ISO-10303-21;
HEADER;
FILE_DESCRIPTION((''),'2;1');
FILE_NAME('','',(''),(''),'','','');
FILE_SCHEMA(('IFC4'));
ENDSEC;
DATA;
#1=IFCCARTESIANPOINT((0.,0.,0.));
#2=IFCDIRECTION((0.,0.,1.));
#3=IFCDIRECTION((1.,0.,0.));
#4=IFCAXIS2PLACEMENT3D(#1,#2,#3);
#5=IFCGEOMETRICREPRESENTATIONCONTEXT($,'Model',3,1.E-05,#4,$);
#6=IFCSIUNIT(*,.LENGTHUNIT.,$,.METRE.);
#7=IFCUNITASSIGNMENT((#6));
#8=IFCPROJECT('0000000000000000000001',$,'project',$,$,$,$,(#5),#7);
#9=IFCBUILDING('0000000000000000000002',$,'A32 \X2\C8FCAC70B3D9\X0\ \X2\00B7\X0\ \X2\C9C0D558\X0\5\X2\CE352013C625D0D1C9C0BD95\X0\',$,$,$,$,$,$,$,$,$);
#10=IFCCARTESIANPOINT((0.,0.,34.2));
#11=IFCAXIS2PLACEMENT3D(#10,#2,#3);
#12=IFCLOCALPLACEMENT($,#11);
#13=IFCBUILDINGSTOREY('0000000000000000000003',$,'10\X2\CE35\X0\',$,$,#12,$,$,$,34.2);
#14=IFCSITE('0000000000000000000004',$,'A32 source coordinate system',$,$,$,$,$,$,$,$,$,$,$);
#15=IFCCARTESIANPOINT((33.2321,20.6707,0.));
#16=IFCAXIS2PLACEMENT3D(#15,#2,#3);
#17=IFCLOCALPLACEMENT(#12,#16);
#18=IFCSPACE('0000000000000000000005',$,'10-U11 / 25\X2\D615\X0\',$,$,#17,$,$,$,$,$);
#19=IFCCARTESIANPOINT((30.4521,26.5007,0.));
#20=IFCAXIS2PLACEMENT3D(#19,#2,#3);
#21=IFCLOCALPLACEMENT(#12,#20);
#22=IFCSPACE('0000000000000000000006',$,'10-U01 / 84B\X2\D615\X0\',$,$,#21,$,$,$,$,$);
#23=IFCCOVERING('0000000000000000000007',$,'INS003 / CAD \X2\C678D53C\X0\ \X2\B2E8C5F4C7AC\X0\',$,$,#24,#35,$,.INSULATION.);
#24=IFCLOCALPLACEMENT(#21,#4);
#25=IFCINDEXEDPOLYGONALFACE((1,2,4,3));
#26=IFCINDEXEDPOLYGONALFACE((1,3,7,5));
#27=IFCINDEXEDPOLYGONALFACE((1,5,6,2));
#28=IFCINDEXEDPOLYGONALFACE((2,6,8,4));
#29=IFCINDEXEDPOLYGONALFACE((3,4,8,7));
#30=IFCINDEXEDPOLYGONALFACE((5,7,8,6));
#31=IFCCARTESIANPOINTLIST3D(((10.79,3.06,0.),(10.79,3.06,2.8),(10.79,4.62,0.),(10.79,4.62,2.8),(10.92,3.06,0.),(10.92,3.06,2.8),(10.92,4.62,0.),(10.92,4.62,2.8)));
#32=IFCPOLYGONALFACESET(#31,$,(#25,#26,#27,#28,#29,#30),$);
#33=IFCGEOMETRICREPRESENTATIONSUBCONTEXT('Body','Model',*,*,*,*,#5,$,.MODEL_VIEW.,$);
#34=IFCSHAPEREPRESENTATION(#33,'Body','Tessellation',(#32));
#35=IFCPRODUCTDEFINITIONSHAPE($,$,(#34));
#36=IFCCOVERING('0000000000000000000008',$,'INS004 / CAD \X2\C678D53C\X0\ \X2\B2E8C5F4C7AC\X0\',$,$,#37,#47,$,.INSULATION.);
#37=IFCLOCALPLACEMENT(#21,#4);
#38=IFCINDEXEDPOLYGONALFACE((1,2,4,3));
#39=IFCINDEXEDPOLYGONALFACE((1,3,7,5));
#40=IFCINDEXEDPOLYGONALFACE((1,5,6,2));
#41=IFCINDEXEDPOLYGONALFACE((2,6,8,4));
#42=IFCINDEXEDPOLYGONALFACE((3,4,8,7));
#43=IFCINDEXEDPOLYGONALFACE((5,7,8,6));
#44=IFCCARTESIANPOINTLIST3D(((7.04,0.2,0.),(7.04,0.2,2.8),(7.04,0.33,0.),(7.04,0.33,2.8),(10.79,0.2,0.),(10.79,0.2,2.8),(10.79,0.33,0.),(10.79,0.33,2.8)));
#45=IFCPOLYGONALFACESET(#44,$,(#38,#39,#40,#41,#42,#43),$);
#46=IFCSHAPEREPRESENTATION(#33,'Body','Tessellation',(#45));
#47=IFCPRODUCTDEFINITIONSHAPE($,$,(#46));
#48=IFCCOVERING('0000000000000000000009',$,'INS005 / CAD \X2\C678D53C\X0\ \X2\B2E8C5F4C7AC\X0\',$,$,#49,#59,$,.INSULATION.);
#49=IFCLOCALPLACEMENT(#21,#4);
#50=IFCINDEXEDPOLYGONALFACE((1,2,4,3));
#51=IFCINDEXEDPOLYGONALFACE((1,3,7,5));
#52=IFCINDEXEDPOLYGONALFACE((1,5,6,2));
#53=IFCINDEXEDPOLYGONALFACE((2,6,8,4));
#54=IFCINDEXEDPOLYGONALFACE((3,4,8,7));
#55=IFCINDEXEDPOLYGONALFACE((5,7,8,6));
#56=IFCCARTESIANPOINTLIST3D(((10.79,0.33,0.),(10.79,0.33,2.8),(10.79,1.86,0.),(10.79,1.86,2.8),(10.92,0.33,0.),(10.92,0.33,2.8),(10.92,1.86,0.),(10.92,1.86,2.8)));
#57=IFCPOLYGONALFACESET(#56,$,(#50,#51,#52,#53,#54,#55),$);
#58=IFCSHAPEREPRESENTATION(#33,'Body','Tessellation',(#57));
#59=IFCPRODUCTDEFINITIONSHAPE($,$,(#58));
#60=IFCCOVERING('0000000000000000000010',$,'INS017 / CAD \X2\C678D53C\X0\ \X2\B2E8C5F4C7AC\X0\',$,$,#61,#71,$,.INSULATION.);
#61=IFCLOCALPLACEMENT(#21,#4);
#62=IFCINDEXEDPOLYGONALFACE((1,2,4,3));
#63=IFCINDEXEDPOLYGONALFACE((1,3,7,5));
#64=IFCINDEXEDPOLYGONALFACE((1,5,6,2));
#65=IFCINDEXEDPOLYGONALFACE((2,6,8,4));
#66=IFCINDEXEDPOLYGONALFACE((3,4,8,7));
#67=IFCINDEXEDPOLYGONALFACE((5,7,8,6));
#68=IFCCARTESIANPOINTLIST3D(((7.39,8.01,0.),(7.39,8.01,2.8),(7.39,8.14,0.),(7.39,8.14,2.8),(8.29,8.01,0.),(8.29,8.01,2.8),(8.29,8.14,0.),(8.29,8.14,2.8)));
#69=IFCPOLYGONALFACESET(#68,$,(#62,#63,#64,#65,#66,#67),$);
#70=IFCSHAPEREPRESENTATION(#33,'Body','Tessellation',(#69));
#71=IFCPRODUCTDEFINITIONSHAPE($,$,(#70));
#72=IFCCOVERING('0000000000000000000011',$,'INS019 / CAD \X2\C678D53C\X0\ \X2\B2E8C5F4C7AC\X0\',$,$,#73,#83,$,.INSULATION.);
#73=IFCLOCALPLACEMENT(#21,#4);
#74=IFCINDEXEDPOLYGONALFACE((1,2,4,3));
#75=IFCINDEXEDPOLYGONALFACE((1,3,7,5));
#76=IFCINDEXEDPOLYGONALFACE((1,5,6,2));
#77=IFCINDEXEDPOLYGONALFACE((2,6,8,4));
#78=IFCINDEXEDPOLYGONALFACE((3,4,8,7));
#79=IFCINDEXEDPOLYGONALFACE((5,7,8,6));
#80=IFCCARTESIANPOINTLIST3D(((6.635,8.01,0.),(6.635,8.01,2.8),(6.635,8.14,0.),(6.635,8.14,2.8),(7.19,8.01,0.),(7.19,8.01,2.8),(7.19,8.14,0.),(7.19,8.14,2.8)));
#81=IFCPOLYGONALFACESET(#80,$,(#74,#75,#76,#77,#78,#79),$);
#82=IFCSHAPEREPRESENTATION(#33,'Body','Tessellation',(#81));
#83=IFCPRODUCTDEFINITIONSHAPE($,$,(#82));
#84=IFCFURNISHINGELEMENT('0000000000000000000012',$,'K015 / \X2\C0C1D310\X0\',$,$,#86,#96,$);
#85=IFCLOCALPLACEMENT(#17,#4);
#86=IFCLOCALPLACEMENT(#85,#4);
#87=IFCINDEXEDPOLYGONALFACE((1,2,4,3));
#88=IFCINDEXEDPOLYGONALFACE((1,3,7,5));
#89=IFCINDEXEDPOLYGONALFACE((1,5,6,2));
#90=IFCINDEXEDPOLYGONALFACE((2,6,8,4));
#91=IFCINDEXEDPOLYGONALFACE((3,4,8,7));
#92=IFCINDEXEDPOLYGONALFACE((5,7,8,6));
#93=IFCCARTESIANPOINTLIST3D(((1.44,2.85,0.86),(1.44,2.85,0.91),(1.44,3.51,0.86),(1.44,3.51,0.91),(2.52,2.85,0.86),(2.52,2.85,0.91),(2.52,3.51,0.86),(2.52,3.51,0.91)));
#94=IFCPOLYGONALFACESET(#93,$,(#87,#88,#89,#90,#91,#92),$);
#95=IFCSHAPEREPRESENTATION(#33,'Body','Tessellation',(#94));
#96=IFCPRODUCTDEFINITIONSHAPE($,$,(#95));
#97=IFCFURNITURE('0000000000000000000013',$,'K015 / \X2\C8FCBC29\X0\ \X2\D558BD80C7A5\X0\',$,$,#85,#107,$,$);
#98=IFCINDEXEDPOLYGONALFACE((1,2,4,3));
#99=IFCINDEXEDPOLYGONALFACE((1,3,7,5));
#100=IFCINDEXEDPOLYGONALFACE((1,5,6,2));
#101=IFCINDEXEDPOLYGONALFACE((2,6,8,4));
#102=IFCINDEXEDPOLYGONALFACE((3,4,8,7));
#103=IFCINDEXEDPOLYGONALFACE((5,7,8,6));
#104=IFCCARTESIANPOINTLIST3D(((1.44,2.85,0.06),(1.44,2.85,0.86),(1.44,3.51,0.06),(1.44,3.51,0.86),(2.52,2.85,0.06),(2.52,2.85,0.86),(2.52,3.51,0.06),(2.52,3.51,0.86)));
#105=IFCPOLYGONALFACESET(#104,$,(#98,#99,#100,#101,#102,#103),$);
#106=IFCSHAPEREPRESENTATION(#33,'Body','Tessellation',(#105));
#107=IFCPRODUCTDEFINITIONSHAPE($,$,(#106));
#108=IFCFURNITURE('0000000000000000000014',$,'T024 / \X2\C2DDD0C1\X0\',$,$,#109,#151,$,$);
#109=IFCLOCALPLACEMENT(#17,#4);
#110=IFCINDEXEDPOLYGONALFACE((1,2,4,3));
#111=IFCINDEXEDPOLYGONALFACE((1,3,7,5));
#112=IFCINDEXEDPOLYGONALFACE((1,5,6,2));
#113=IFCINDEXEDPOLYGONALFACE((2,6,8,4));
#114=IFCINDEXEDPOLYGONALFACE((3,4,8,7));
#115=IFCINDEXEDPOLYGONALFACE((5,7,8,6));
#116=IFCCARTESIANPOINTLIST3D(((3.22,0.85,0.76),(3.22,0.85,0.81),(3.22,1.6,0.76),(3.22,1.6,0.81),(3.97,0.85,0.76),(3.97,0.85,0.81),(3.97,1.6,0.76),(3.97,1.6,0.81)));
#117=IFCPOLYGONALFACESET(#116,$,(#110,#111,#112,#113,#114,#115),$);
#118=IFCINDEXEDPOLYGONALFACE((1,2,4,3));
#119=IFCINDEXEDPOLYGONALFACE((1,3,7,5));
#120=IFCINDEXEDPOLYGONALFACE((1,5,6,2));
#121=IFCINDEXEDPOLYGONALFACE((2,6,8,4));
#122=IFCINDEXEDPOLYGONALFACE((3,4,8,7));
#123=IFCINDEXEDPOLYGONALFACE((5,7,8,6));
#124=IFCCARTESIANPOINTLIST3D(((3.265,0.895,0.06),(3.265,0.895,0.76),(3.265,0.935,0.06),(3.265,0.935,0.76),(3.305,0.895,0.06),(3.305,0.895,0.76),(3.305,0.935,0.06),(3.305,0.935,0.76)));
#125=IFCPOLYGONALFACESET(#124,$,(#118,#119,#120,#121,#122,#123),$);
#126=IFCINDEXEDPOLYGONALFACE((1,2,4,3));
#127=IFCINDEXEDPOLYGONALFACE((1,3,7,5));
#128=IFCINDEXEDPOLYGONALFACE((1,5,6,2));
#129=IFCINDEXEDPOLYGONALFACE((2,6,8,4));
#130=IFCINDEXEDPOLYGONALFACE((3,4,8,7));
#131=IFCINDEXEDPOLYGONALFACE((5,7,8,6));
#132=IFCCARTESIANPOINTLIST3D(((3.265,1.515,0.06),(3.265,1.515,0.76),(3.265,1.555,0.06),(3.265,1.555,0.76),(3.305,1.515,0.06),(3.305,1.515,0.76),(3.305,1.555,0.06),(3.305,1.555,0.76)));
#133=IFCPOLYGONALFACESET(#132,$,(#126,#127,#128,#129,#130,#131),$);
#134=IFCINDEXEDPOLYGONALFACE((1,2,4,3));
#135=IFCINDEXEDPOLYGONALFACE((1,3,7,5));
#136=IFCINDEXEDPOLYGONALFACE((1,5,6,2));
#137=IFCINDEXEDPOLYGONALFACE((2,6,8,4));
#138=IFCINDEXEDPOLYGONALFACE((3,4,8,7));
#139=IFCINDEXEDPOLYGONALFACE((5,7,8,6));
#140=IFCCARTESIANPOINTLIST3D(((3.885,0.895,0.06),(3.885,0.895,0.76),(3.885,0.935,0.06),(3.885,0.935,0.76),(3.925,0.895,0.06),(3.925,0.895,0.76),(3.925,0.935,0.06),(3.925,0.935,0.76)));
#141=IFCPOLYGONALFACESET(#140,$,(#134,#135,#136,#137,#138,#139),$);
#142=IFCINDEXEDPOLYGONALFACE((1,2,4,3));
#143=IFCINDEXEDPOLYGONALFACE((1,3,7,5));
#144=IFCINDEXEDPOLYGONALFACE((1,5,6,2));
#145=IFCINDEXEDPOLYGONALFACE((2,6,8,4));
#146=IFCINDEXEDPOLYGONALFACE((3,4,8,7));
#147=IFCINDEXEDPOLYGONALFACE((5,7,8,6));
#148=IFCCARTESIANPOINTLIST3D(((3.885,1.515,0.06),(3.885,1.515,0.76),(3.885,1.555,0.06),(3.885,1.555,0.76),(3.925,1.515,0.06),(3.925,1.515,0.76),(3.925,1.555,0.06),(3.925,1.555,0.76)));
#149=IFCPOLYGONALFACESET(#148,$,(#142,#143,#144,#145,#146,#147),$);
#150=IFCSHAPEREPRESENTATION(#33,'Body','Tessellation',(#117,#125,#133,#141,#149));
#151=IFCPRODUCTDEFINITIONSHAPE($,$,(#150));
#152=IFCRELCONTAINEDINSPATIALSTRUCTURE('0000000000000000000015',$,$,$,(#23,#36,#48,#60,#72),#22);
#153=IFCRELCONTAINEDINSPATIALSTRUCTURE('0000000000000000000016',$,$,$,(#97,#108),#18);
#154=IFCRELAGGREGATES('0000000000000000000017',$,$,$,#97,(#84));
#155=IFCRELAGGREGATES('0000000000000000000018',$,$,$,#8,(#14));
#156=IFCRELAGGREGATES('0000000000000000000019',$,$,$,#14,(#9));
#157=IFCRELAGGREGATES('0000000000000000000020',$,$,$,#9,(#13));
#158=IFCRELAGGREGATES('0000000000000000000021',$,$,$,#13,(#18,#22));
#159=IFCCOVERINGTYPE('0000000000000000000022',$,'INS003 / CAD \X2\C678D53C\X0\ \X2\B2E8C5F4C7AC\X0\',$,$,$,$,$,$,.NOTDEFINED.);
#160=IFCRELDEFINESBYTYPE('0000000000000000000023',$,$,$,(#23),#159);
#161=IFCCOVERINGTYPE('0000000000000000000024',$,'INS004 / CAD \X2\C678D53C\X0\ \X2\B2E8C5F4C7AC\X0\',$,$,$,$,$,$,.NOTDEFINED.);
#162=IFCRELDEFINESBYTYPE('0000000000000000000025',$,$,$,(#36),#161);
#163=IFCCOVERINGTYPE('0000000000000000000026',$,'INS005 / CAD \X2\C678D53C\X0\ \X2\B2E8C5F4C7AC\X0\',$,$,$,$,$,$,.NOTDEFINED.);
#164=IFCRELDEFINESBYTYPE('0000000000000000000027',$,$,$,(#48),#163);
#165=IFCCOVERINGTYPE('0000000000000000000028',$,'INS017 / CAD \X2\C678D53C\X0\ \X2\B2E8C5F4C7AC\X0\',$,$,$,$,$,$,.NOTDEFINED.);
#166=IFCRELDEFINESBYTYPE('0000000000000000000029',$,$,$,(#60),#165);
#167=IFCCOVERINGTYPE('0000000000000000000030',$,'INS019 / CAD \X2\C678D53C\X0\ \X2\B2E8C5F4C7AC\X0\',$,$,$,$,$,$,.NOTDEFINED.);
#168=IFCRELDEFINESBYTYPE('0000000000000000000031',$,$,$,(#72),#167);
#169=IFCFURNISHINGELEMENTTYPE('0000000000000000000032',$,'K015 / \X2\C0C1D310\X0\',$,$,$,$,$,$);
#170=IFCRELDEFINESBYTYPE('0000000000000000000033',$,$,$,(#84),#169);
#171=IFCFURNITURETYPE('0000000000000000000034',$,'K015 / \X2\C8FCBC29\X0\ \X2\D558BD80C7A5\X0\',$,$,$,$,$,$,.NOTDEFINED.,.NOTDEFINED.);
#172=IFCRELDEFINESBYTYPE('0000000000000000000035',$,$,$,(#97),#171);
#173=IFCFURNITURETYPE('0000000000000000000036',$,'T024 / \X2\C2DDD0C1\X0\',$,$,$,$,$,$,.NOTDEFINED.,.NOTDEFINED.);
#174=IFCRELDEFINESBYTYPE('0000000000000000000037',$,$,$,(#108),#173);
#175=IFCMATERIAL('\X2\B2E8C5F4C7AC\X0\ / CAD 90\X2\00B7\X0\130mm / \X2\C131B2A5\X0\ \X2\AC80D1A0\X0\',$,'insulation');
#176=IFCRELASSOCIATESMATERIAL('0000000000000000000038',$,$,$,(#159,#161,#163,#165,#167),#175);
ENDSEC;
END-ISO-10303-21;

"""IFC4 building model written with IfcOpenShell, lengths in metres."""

from ifc_helpers import new_model, si_unit, frame, origin, origin_with_axes, place, context, subcontext, project, spatial, polyline, outline, extrude, source, transform, mapped, material, type_object, type_shapes, element, aggregate, save


model = new_model("IFC4")

# Units and contexts
model_context = context("Model", 3, precision=1e-05, world=origin_with_axes())
body_context = subcontext(model_context, "Body", "Model", "MODEL_VIEW")
ifc_project = project(units=[si_unit("LENGTHUNIT", "METRE")], contexts=[model_context])

# Site, building, storey, space
site = spatial("IfcSite", under=ifc_project, Name="A32 source coordinate system")
building = spatial("IfcBuilding", under=site, Name="A32 주거동 · 지하5층–옥탑지붕")
storey_placement = place(None, frame((0.0, 0.0, 34.2), z_axis=(0.0, 0.0, 1.0), x_axis=(1.0, 0.0, 0.0)))
storey = spatial("IfcBuildingStorey", under=building, at=storey_placement, Name="10층", Elevation=34.2)
space_1_placement = place(storey_placement, frame((33.2321, 20.6707, 0.0), z_axis=(0.0, 0.0, 1.0), x_axis=(1.0, 0.0, 0.0)))
space_1 = spatial("IfcSpace", under=storey, at=space_1_placement, Name="10-U11 / 25형")

# Shared definitions
space_2_placement = place(storey_placement, frame((30.4521, 26.5007, 0.0), z_axis=(0.0, 0.0, 1.0), x_axis=(1.0, 0.0, 0.0)))
space_2 = spatial("IfcSpace", under=storey, at=space_2_placement, Name="10-U01 / 84B형")

# Coverings
ifc_material = material(Name="단열재 / CAD 90·130mm / 성능 검토", Category="insulation")
covering_type_1 = type_object("IfcCoveringType", Name="INS003 / CAD 외피 단열재", PredefinedType="NOTDEFINED", material=ifc_material)
shared_shape_1 = source(origin(), body_context, "Body", "SweptSolid", [
    extrude(outline(polyline([(10.79, 3.06), (10.79, 4.62), (10.92, 4.62), (10.92, 3.06), (10.79, 3.06)])), origin(), (0.0, 0.0, 1.0), 2.8),
])
type_shapes(covering_type_1, [shared_shape_1])
covering_1_placement = place(space_2_placement, origin_with_axes())
element("IfcCovering", 1, at=covering_1_placement, inside=space_2, type_object=covering_type_1, Name="INS003 / CAD 외피 단열재", PredefinedType="INSULATION", context=body_context, shape_type="MappedRepresentation", body=[
    mapped(shared_shape_1, transform((0.0, 0.0, 0.0), scale=1.0)),
])
covering_type_2 = type_object("IfcCoveringType", Name="INS004 / CAD 외피 단열재", PredefinedType="NOTDEFINED", material=ifc_material)
shared_shape_2 = source(origin(), body_context, "Body", "SweptSolid", [
    extrude(outline(polyline([(7.04, 0.33), (10.79, 0.33), (10.79, 0.2), (7.04, 0.2), (7.04, 0.33)])), origin(), (0.0, 0.0, 1.0), 2.8),
])
type_shapes(covering_type_2, [shared_shape_2])
covering_2_placement = place(space_2_placement, origin_with_axes())
element("IfcCovering", 2, at=covering_2_placement, inside=space_2, type_object=covering_type_2, Name="INS004 / CAD 외피 단열재", PredefinedType="INSULATION", context=body_context, shape_type="MappedRepresentation", body=[
    mapped(shared_shape_2, transform((0.0, 0.0, 0.0), scale=1.0)),
])
covering_type_3 = type_object("IfcCoveringType", Name="INS005 / CAD 외피 단열재", PredefinedType="NOTDEFINED", material=ifc_material)
shared_shape_3 = source(origin(), body_context, "Body", "SweptSolid", [
    extrude(outline(polyline([(10.79, 0.33), (10.79, 1.86), (10.92, 1.86), (10.92, 0.33), (10.79, 0.33)])), origin(), (0.0, 0.0, 1.0), 2.8),
])
type_shapes(covering_type_3, [shared_shape_3])
covering_3_placement = place(space_2_placement, origin_with_axes())
element("IfcCovering", 3, at=covering_3_placement, inside=space_2, type_object=covering_type_3, Name="INS005 / CAD 외피 단열재", PredefinedType="INSULATION", context=body_context, shape_type="MappedRepresentation", body=[
    mapped(shared_shape_3, transform((0.0, 0.0, 0.0), scale=1.0)),
])
covering_type_4 = type_object("IfcCoveringType", Name="INS017 / CAD 외피 단열재", PredefinedType="NOTDEFINED", material=ifc_material)
shared_shape_4 = source(origin(), body_context, "Body", "SweptSolid", [
    extrude(outline(polyline([(8.29, 8.01), (7.39, 8.01), (7.39, 8.14), (8.29, 8.14), (8.29, 8.01)])), origin(), (0.0, 0.0, 1.0), 2.8),
])
type_shapes(covering_type_4, [shared_shape_4])
covering_4_placement = place(space_2_placement, origin_with_axes())
element("IfcCovering", 4, at=covering_4_placement, inside=space_2, type_object=covering_type_4, Name="INS017 / CAD 외피 단열재", PredefinedType="INSULATION", context=body_context, shape_type="MappedRepresentation", body=[
    mapped(shared_shape_4, transform((0.0, 0.0, 0.0), scale=1.0)),
])
covering_type_5 = type_object("IfcCoveringType", Name="INS019 / CAD 외피 단열재", PredefinedType="NOTDEFINED", material=ifc_material)
shared_shape_5 = source(origin(), body_context, "Body", "SweptSolid", [
    extrude(outline(polyline([(6.635, 8.01), (6.635, 8.14), (7.19, 8.14), (7.19, 8.01), (6.635, 8.01)])), origin(), (0.0, 0.0, 1.0), 2.8),
])
type_shapes(covering_type_5, [shared_shape_5])
covering_5_placement = place(space_2_placement, origin_with_axes())
element("IfcCovering", 5, at=covering_5_placement, inside=space_2, type_object=covering_type_5, Name="INS019 / CAD 외피 단열재", PredefinedType="INSULATION", context=body_context, shape_type="MappedRepresentation", body=[
    mapped(shared_shape_5, transform((0.0, 0.0, 0.0), scale=1.0)),
])

# Furnishing element
furnishing_element_type_1 = type_object("IfcFurnishingElementType", Name="K015 / 상판")
shared_shape_6 = source(origin(), body_context, "Body", "SweptSolid", [
    extrude(outline(polyline([(2.52, 2.85), (1.44, 2.85), (1.44, 3.51), (2.52, 3.51), (2.52, 2.85)])), frame((0.0, 0.0, 0.86)), (0.0, 0.0, 1.0), 0.05),
])
type_shapes(furnishing_element_type_1, [shared_shape_6])
furniture_1_placement = place(space_1_placement, origin_with_axes())
furnishing_1_placement = place(furniture_1_placement, origin_with_axes())
furnishing_1 = element("IfcFurnishingElement", 6, at=furnishing_1_placement, type_object=furnishing_element_type_1, Name="K015 / 상판", context=body_context, shape_type="MappedRepresentation", body=[
    mapped(shared_shape_6, transform((0.0, 0.0, 0.0), scale=1.0)),
])

# Furniture
furniture_type_1 = type_object("IfcFurnitureType", Name="K015 / 주방 하부장", AssemblyPlace="NOTDEFINED", PredefinedType="NOTDEFINED")
shared_shape_7 = source(origin(), body_context, "Body", "SweptSolid", [
    extrude(outline(polyline([(2.52, 3.51), (2.52, 2.85), (1.44, 2.85), (1.44, 3.51), (2.52, 3.51)])), frame((0.0, 0.0, 0.06)), (0.0, 0.0, 1.0), 0.8),
])
type_shapes(furniture_type_1, [shared_shape_7])
furniture_1 = element("IfcFurniture", 7, at=furniture_1_placement, inside=space_1, type_object=furniture_type_1, Name="K015 / 주방 하부장", context=body_context, shape_type="MappedRepresentation", body=[
    mapped(shared_shape_7, transform((0.0, 0.0, 0.0), scale=1.0)),
])
aggregate(furniture_1, [furnishing_1])
furniture_type_2 = type_object("IfcFurnitureType", Name="T024 / 식탁", AssemblyPlace="NOTDEFINED", PredefinedType="NOTDEFINED")
shared_shape_8 = source(origin(), body_context, "Body", "SweptSolid", [
    extrude(outline(polyline([(3.22, 0.85), (3.22, 1.6), (3.97, 1.6), (3.97, 0.85), (3.22, 0.85)])), frame((0.0, 0.0, 0.76)), (0.0, 0.0, 1.0), 0.05),
    extrude(outline(polyline([(3.265, 0.895), (3.265, 0.935), (3.305, 0.935), (3.305, 0.895), (3.265, 0.895)])), frame((0.0, 0.0, 0.06)), (0.0, 0.0, 1.0), 0.7),
    extrude(outline(polyline([(3.265, 1.515), (3.265, 1.555), (3.305, 1.555), (3.305, 1.515), (3.265, 1.515)])), frame((0.0, 0.0, 0.06)), (0.0, 0.0, 1.0), 0.7),
    extrude(outline(polyline([(3.885, 0.895), (3.885, 0.935), (3.925, 0.935), (3.925, 0.895), (3.885, 0.895)])), frame((0.0, 0.0, 0.06)), (0.0, 0.0, 1.0), 0.7),
    extrude(outline(polyline([(3.885, 1.515), (3.885, 1.555), (3.925, 1.555), (3.925, 1.515), (3.885, 1.515)])), frame((0.0, 0.0, 0.06)), (0.0, 0.0, 1.0), 0.7),
])
type_shapes(furniture_type_2, [shared_shape_8])
furniture_2_placement = place(space_1_placement, origin_with_axes())
element("IfcFurniture", 8, at=furniture_2_placement, inside=space_1, type_object=furniture_type_2, Name="T024 / 식탁", context=body_context, shape_type="MappedRepresentation", body=[
    mapped(shared_shape_8, transform((0.0, 0.0, 0.0), scale=1.0)),
])

save(model, "model.ifc")
